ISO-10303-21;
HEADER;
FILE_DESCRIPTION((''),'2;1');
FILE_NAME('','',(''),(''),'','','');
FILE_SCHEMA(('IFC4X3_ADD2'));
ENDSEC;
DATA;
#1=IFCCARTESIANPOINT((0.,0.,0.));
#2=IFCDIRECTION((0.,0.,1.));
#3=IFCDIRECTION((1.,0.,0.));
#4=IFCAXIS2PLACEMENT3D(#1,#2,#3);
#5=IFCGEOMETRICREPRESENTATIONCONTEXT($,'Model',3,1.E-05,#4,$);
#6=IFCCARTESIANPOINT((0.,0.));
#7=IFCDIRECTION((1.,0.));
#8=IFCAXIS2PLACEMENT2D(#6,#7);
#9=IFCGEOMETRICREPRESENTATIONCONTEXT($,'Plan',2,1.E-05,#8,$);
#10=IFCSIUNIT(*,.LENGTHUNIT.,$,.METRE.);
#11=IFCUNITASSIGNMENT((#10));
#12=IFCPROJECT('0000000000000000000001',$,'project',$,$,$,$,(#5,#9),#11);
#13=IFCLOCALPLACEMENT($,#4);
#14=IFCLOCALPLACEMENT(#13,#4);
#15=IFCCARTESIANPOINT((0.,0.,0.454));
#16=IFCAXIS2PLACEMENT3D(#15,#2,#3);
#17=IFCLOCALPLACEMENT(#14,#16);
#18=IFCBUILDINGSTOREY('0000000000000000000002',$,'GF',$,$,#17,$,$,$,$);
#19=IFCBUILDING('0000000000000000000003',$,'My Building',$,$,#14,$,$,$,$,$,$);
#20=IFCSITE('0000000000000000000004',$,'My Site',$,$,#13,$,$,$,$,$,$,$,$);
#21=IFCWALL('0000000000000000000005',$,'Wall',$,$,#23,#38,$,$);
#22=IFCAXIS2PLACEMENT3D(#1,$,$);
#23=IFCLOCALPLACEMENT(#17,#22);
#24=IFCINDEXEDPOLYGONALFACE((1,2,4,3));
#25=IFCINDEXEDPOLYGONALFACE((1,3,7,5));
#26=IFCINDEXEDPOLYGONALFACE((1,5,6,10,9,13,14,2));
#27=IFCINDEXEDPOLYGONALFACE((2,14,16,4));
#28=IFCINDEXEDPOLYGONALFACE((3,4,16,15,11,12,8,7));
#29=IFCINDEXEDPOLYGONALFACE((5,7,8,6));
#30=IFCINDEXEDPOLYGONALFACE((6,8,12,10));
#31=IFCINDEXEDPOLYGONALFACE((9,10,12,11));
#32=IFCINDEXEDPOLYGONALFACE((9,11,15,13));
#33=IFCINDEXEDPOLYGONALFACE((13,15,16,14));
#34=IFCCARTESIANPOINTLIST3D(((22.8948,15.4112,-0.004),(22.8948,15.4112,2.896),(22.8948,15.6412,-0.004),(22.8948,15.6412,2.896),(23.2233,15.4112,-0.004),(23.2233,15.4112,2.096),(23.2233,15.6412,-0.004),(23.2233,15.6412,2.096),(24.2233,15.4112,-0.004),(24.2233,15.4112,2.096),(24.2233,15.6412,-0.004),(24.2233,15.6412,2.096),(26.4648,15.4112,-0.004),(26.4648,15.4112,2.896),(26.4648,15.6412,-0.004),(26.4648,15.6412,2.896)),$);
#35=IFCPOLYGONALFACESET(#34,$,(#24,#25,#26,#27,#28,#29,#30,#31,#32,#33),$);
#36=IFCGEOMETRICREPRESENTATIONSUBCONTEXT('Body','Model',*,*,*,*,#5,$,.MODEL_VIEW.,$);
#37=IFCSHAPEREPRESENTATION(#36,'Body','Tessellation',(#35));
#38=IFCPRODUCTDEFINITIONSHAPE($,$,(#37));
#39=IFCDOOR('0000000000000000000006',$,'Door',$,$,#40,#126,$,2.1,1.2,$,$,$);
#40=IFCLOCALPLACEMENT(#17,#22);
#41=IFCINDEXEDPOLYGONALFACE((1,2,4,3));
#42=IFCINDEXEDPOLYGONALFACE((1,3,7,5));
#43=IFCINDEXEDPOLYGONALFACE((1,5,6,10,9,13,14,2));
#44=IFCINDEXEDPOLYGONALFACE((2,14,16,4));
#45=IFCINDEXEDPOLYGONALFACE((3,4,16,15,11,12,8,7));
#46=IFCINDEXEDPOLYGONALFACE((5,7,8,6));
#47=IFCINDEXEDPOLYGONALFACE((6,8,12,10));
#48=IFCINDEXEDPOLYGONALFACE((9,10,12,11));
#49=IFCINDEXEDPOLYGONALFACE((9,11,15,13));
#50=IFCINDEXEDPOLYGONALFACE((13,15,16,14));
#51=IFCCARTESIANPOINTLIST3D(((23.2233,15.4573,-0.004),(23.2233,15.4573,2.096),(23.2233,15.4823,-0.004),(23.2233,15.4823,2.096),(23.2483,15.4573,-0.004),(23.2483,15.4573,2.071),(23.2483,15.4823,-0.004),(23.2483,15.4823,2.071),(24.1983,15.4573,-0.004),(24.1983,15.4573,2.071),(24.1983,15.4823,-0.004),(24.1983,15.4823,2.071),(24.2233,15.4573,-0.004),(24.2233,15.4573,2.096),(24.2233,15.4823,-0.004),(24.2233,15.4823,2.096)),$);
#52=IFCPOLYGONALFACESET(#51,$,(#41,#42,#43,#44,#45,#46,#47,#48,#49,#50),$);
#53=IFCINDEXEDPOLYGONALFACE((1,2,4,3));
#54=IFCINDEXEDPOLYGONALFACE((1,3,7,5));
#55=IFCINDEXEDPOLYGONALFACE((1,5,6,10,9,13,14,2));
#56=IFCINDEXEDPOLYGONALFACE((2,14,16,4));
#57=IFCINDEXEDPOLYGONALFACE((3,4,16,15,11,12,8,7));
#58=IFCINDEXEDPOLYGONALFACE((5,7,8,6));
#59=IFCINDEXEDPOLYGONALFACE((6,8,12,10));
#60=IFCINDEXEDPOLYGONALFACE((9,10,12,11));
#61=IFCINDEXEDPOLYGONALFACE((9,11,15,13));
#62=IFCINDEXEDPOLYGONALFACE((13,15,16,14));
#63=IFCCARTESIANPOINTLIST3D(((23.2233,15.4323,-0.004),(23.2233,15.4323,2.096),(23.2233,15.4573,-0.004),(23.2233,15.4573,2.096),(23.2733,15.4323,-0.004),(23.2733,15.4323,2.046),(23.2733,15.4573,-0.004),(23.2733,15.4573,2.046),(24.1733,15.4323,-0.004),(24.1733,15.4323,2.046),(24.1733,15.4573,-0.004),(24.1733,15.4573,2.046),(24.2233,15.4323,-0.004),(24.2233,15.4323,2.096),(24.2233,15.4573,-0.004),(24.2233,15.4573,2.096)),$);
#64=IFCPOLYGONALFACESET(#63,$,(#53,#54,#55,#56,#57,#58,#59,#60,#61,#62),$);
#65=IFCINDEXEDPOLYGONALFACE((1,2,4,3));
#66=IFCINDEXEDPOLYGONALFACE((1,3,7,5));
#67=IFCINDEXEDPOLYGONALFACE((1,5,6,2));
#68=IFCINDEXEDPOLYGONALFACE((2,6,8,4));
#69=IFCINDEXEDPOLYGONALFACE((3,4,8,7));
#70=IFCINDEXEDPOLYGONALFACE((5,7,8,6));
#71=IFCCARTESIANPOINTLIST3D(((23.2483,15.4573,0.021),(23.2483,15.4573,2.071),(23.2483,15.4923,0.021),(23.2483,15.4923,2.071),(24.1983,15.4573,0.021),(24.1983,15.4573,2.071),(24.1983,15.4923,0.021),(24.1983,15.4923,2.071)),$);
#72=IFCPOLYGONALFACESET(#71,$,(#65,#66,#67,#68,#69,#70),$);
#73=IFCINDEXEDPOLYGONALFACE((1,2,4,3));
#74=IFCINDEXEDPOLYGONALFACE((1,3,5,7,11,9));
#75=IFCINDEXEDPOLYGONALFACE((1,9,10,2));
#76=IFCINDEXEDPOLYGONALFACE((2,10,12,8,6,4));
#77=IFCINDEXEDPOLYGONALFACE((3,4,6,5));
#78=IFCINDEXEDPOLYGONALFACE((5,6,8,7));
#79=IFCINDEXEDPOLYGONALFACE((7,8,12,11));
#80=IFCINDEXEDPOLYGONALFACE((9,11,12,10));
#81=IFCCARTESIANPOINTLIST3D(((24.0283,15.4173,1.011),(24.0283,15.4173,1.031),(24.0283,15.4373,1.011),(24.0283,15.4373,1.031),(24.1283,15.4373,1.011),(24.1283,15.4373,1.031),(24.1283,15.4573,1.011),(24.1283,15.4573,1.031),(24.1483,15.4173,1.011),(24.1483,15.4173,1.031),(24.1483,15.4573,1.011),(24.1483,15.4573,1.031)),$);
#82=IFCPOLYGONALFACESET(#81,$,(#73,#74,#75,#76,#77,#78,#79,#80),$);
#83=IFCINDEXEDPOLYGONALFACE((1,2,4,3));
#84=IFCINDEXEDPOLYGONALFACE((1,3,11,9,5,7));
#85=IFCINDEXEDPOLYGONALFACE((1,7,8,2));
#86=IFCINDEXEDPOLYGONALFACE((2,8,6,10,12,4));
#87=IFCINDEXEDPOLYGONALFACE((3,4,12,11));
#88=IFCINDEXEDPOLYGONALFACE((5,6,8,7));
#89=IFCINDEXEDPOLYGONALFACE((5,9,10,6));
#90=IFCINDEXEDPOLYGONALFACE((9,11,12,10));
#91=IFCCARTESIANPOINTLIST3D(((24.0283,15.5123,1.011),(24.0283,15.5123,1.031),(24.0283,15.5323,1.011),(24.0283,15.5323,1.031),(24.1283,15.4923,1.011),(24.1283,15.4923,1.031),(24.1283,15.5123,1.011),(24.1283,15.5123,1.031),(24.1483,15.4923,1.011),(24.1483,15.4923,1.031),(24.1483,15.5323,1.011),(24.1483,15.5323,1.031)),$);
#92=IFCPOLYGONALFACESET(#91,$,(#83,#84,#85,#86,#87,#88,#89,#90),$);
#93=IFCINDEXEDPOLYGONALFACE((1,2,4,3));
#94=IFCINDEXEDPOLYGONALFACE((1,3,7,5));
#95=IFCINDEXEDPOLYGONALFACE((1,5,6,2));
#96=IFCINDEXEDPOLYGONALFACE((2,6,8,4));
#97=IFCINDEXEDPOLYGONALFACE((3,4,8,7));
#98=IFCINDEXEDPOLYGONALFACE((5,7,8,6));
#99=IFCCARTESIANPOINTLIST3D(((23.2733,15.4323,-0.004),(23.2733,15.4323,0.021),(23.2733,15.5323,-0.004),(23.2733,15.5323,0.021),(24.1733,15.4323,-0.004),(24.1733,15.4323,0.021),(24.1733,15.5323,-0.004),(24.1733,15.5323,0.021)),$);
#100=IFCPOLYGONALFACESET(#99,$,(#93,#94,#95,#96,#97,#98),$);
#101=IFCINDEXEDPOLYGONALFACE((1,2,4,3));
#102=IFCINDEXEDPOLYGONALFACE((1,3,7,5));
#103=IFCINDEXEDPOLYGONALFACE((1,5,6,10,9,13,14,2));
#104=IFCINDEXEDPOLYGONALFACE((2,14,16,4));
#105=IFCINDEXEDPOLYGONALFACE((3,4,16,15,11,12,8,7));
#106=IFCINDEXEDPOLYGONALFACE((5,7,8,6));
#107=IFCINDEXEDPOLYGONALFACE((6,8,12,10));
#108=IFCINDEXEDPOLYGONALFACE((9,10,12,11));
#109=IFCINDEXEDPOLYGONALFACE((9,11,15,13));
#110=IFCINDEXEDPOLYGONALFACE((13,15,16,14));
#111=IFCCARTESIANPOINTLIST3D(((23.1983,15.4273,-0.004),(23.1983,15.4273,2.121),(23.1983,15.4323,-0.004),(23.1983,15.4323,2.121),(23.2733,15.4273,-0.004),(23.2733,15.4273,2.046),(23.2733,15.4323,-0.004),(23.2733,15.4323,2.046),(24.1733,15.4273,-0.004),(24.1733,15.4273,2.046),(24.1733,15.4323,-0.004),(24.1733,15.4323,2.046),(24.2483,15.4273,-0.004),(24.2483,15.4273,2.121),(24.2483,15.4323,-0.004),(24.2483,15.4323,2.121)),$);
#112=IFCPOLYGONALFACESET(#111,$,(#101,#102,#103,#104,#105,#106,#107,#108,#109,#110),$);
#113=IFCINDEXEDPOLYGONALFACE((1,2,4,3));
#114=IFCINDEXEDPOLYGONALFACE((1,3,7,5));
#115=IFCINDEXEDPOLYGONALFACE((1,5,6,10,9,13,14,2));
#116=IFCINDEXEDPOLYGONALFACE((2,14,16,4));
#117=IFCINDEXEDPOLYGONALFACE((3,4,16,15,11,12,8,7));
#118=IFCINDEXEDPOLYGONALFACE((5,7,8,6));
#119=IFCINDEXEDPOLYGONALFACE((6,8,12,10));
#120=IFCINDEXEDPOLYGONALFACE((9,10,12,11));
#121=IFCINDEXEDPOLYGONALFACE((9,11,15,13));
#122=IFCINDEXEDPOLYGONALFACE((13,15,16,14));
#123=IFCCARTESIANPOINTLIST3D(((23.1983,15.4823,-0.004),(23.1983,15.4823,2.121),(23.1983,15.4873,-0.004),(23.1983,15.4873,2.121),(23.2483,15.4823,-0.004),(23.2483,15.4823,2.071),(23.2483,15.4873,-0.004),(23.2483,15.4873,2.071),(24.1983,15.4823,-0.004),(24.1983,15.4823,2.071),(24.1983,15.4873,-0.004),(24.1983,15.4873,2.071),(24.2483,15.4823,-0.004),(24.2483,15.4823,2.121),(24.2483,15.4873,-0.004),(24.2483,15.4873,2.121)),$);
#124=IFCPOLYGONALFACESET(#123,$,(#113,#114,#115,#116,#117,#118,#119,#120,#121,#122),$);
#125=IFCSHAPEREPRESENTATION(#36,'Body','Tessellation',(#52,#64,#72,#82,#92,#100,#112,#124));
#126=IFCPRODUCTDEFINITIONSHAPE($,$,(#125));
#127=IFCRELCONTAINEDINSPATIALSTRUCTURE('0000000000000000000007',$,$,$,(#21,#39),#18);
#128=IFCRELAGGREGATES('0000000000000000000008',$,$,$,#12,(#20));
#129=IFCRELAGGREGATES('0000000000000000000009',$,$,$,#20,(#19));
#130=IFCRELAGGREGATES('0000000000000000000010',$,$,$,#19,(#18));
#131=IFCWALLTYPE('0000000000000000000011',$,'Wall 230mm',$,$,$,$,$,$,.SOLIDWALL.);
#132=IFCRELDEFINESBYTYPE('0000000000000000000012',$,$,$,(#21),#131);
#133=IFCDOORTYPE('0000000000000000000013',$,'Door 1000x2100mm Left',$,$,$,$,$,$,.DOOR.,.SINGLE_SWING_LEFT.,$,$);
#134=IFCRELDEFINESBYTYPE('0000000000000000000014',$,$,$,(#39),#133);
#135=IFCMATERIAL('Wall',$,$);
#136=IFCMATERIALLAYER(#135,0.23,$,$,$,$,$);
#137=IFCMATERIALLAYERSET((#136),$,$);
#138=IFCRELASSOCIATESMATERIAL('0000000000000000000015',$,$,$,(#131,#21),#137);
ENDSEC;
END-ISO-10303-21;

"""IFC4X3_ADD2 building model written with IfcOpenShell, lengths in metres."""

from ifc_helpers import new_model, entity, si_unit, frame, origin_with_axes, origin_2d_with_axis, place, context, subcontext, project, spatial, line, indexed_curve, outline, extrude, shape, source, transform, mapped, material, layer, layer_set, layer_usage, type_object, type_shapes, element, fill, save


model = new_model("IFC4X3_ADD2")

# Units and contexts
model_context = context("Model", 3, precision=1e-05, world=origin_with_axes())
plan_context = context("Plan", 2, precision=1e-05, world=origin_2d_with_axis())
body_context_1 = subcontext(model_context, "Body", "Model", "MODEL_VIEW")
body_context_2 = subcontext(plan_context, "Body", "Plan", "PLAN_VIEW")
ifc_project = project(units=[si_unit("LENGTHUNIT", "METRE")], contexts=[model_context, plan_context])

# Site, building, storey
site_placement = place(None, origin_with_axes())
site = spatial("IfcSite", under=ifc_project, at=site_placement, Name="My Site")
building_placement = place(site_placement, origin_with_axes())
building = spatial("IfcBuilding", under=site, at=building_placement, Name="My Building")
storey_placement = place(building_placement, frame((0.0, 0.0, 0.454), z_axis=(0.0, 0.0, 1.0), x_axis=(1.0, 0.0, 0.0)))
storey = spatial("IfcBuildingStorey", under=building, at=storey_placement, Name="GF")

# Shared definitions
ifc_material_1 = material(Name="Wall")

# Shared definitions
ifc_layer_1 = layer(ifc_material_1, 0.23)
ifc_layer_set_1 = layer_set([ifc_layer_1])
wall_type_1 = type_object("IfcWallType", Name="Wall 230mm", PredefinedType="SOLIDWALL", material=ifc_layer_set_1)

# Wall, opening, door
ifc_layer_usage_1 = layer_usage(ifc_layer_set_1, "AXIS2", "POSITIVE", 0.0)
wall_1_placement = place(storey_placement, frame((26.4648, 15.6412, -0.004), z_axis=(0.0, 0.0, 1.0), x_axis=(-1.0, 0.0, 0.0)))
wall_1 = element("IfcWall", 1, at=wall_1_placement, inside=storey, type_object=wall_type_1, material=ifc_layer_usage_1, Name="Wall", context=body_context_1, shape_type="SweptSolid", body=[
    extrude(outline(indexed_curve([(0.0, 0.0), (0.0, 0.23), (3.57, 0.23), (3.57, 0.0), (0.0, 0.0)], self_intersect=False)), origin_with_axes(), (0.0, 0.0, 1.0), 2.9),
])
shared_shape_1 = source(origin_with_axes(), body_context_1, "Body", "SweptSolid", [
    extrude(outline(indexed_curve([(0.0, 0.0), (1.0, 0.0), (1.0, 2.1), (0.0, 2.1)], segments=[line(1, 2, 3, 4, 1)])), frame((0.0, -0.6, 0.0), z_axis=(0.0, -1.0, 0.0), x_axis=(1.0, 0.0, 0.0)), (0.0, 0.0, -1.0), 1.2),
])
opening_1_placement = place(wall_1_placement, frame((3.2415, 0.209, 0.0), z_axis=(0.0, 0.0, 1.0), x_axis=(-1.0, 0.0, 0.0)))
opening_1 = element("IfcOpeningElement", 2, at=opening_1_placement, cuts=wall_1, PredefinedType="OPENING", context=body_context_1, shape_type="MappedRepresentation", body=[
    mapped(shared_shape_1, transform((0.0, 0.0, 0.0), x_axis=(1.0, 0.0, 0.0), y_axis=(0.0, 1.0, 0.0), z_axis=(0.0, 0.0, 1.0), scale=1.0)),
])
door_type_1 = type_object("IfcDoorType", Name="Door 1000x2100mm Left", OperationType="SINGLE_SWING_LEFT", PredefinedType="DOOR")
shared_shape_2 = source(origin_with_axes(), body_context_1, "Body", "SweptSolid", [
    extrude(outline(indexed_curve([(0.0, 0.0), (0.0, 2.1), (1.0, 2.1), (1.0, 0.0), (0.975, 0.0), (0.975, 2.075), (0.025, 2.075), (0.025, 0.0)], segments=[line(1, 2, 3, 4, 5, 6, 7, 8, 1)])), frame((0.0, 0.025, 0.0), z_axis=(0.0, -1.0, 0.0), x_axis=(1.0, 0.0, 0.0)), (0.0, 0.0, -1.0), 0.025),
    extrude(outline(indexed_curve([(0.0, 0.0), (0.0, 2.1), (1.0, 2.1), (1.0, 0.0), (0.95, 0.0), (0.95, 2.05), (0.05, 2.05), (0.05, 0.0)], segments=[line(1, 2, 3, 4, 5, 6, 7, 8, 1)])), frame((0.0, 0.0, 0.0), z_axis=(0.0, -1.0, 0.0), x_axis=(1.0, 0.0, 0.0)), (0.0, 0.0, -1.0), 0.025),
    extrude(outline(indexed_curve([(0.0, 0.0), (0.95, 0.0), (0.95, 0.035), (0.0, 0.035)], segments=[line(1, 2, 3, 4, 1)])), frame((0.025, 0.025, 0.025), z_axis=(0.0, 0.0, 1.0), x_axis=(1.0, 0.0, 0.0)), (0.0, 0.0, 1.0), 2.05),
    extrude(outline(indexed_curve([(0.0, 0.0), (0.0, -0.04), (-0.12, -0.04), (-0.12, -0.02), (-0.02, -0.02), (-0.02, 0.0)], segments=[line(1, 2, 3, 4, 5, 6, 1)])), frame((0.925, 0.025, 1.015), z_axis=(0.0, 0.0, 1.0), x_axis=(1.0, 0.0, 0.0)), (0.0, 0.0, 1.0), 0.02),
    extrude(outline(indexed_curve([(0.0, 0.0), (0.0, 0.04), (-0.12, 0.04), (-0.12, 0.02), (-0.02, 0.02), (-0.02, 0.0)], segments=[line(1, 2, 3, 4, 5, 6, 1)])), frame((0.925, 0.06, 1.015), z_axis=(0.0, 0.0, 1.0), x_axis=(1.0, 0.0, 0.0)), (0.0, 0.0, 1.0), 0.02),
    extrude(outline(indexed_curve([(0.0, 0.0), (0.9, 0.0), (0.9, 0.1), (0.0, 0.1)], segments=[line(1, 2, 3, 4, 1)])), frame((0.05, 0.0, 0.0), z_axis=(0.0, 0.0, 1.0), x_axis=(1.0, 0.0, 0.0)), (0.0, 0.0, 1.0), 0.025),
    extrude(outline(indexed_curve([(0.0, 0.0), (0.0, 2.125), (1.05, 2.125), (1.05, 0.0), (0.975, 0.0), (0.975, 2.05), (0.075, 2.05), (0.075, 0.0)], segments=[line(1, 2, 3, 4, 5, 6, 7, 8, 1)])), frame((-0.025, -0.005, 0.0), z_axis=(0.0, -1.0, 0.0), x_axis=(1.0, 0.0, 0.0)), (0.0, 0.0, -1.0), 0.005),
    extrude(outline(indexed_curve([(0.0, 0.0), (0.0, 2.125), (1.05, 2.125), (1.05, 0.0), (1.0, 0.0), (1.0, 2.075), (0.05, 2.075), (0.05, 0.0)], segments=[line(1, 2, 3, 4, 5, 6, 7, 8, 1)])), frame((-0.025, 0.05, 0.0), z_axis=(0.0, -1.0, 0.0), x_axis=(1.0, 0.0, 0.0)), (0.0, 0.0, -1.0), 0.005),
])
shared_shape_3 = source(origin_with_axes(), body_context_2, "Body", "Curve2D", [
    entity("IfcIndexedPolyCurve", entity("IfcCartesianPointList2D", [[0.0, 0.0], [0.0, 0.05], [0.025, 0.05], [0.025, 0.025], [0.05, 0.025], [0.05, 0.0]]), [entity("IfcLineIndex", [1, 2, 3, 4, 5, 6, 1])]),
    entity("IfcIndexedPolyCurve", entity("IfcCartesianPointList2D", [[1.0, 0.0], [1.0, 0.05], [0.975, 0.05], [0.975, 0.025], [0.95, 0.025], [0.95, 0.0]]), [entity("IfcLineIndex", [1, 2, 3, 4, 5, 6, 1])]),
    entity("IfcTrimmedCurve", entity("IfcEllipse", entity("IfcAxis2Placement2D", entity("IfcCartesianPoint", [0.06, 0.05]), entity("IfcDirection", [1.0, 0.0])), 0.915, 0.95), [entity("IfcCartesianPoint", [0.975, 0.05])], [entity("IfcCartesianPoint", [0.06, 1.0])], True, "CARTESIAN"),
    entity("IfcIndexedPolyCurve", entity("IfcCartesianPointList2D", [[0.025, 0.05], [0.06, 0.05], [0.06, 1.0], [0.025, 1.0]]), [entity("IfcLineIndex", [1, 2, 3, 4, 1])]),
])
type_shapes(door_type_1, [shared_shape_2, shared_shape_3])
door_1_placement = place(opening_1_placement, frame((0.0, 0.0, 0.0), z_axis=(0.0, 0.0, 1.0), x_axis=(1.0, 0.0, 0.0)))
door_1 = element("IfcDoor", 3, at=door_1_placement, inside=storey, type_object=door_type_1, Name="Door", OverallHeight=2.1, OverallWidth=1.2, shapes=[
    shape(body_context_1, "Body", "MappedRepresentation", [mapped(shared_shape_2, transform((0.0, 0.0, 0.0), x_axis=(1.0, 0.0, 0.0), y_axis=(0.0, 1.0, 0.0), z_axis=(0.0, 0.0, 1.0), scale=1.0))]),
    shape(body_context_2, "Body", "MappedRepresentation", [mapped(shared_shape_3, transform((0.0, 0.0, 0.0), x_axis=(1.0, 0.0, 0.0), y_axis=(0.0, 1.0, 0.0), z_axis=(0.0, 0.0, 1.0), scale=1.0))]),
])
fill(opening_1, door_1)

save(model, "model.ifc")
